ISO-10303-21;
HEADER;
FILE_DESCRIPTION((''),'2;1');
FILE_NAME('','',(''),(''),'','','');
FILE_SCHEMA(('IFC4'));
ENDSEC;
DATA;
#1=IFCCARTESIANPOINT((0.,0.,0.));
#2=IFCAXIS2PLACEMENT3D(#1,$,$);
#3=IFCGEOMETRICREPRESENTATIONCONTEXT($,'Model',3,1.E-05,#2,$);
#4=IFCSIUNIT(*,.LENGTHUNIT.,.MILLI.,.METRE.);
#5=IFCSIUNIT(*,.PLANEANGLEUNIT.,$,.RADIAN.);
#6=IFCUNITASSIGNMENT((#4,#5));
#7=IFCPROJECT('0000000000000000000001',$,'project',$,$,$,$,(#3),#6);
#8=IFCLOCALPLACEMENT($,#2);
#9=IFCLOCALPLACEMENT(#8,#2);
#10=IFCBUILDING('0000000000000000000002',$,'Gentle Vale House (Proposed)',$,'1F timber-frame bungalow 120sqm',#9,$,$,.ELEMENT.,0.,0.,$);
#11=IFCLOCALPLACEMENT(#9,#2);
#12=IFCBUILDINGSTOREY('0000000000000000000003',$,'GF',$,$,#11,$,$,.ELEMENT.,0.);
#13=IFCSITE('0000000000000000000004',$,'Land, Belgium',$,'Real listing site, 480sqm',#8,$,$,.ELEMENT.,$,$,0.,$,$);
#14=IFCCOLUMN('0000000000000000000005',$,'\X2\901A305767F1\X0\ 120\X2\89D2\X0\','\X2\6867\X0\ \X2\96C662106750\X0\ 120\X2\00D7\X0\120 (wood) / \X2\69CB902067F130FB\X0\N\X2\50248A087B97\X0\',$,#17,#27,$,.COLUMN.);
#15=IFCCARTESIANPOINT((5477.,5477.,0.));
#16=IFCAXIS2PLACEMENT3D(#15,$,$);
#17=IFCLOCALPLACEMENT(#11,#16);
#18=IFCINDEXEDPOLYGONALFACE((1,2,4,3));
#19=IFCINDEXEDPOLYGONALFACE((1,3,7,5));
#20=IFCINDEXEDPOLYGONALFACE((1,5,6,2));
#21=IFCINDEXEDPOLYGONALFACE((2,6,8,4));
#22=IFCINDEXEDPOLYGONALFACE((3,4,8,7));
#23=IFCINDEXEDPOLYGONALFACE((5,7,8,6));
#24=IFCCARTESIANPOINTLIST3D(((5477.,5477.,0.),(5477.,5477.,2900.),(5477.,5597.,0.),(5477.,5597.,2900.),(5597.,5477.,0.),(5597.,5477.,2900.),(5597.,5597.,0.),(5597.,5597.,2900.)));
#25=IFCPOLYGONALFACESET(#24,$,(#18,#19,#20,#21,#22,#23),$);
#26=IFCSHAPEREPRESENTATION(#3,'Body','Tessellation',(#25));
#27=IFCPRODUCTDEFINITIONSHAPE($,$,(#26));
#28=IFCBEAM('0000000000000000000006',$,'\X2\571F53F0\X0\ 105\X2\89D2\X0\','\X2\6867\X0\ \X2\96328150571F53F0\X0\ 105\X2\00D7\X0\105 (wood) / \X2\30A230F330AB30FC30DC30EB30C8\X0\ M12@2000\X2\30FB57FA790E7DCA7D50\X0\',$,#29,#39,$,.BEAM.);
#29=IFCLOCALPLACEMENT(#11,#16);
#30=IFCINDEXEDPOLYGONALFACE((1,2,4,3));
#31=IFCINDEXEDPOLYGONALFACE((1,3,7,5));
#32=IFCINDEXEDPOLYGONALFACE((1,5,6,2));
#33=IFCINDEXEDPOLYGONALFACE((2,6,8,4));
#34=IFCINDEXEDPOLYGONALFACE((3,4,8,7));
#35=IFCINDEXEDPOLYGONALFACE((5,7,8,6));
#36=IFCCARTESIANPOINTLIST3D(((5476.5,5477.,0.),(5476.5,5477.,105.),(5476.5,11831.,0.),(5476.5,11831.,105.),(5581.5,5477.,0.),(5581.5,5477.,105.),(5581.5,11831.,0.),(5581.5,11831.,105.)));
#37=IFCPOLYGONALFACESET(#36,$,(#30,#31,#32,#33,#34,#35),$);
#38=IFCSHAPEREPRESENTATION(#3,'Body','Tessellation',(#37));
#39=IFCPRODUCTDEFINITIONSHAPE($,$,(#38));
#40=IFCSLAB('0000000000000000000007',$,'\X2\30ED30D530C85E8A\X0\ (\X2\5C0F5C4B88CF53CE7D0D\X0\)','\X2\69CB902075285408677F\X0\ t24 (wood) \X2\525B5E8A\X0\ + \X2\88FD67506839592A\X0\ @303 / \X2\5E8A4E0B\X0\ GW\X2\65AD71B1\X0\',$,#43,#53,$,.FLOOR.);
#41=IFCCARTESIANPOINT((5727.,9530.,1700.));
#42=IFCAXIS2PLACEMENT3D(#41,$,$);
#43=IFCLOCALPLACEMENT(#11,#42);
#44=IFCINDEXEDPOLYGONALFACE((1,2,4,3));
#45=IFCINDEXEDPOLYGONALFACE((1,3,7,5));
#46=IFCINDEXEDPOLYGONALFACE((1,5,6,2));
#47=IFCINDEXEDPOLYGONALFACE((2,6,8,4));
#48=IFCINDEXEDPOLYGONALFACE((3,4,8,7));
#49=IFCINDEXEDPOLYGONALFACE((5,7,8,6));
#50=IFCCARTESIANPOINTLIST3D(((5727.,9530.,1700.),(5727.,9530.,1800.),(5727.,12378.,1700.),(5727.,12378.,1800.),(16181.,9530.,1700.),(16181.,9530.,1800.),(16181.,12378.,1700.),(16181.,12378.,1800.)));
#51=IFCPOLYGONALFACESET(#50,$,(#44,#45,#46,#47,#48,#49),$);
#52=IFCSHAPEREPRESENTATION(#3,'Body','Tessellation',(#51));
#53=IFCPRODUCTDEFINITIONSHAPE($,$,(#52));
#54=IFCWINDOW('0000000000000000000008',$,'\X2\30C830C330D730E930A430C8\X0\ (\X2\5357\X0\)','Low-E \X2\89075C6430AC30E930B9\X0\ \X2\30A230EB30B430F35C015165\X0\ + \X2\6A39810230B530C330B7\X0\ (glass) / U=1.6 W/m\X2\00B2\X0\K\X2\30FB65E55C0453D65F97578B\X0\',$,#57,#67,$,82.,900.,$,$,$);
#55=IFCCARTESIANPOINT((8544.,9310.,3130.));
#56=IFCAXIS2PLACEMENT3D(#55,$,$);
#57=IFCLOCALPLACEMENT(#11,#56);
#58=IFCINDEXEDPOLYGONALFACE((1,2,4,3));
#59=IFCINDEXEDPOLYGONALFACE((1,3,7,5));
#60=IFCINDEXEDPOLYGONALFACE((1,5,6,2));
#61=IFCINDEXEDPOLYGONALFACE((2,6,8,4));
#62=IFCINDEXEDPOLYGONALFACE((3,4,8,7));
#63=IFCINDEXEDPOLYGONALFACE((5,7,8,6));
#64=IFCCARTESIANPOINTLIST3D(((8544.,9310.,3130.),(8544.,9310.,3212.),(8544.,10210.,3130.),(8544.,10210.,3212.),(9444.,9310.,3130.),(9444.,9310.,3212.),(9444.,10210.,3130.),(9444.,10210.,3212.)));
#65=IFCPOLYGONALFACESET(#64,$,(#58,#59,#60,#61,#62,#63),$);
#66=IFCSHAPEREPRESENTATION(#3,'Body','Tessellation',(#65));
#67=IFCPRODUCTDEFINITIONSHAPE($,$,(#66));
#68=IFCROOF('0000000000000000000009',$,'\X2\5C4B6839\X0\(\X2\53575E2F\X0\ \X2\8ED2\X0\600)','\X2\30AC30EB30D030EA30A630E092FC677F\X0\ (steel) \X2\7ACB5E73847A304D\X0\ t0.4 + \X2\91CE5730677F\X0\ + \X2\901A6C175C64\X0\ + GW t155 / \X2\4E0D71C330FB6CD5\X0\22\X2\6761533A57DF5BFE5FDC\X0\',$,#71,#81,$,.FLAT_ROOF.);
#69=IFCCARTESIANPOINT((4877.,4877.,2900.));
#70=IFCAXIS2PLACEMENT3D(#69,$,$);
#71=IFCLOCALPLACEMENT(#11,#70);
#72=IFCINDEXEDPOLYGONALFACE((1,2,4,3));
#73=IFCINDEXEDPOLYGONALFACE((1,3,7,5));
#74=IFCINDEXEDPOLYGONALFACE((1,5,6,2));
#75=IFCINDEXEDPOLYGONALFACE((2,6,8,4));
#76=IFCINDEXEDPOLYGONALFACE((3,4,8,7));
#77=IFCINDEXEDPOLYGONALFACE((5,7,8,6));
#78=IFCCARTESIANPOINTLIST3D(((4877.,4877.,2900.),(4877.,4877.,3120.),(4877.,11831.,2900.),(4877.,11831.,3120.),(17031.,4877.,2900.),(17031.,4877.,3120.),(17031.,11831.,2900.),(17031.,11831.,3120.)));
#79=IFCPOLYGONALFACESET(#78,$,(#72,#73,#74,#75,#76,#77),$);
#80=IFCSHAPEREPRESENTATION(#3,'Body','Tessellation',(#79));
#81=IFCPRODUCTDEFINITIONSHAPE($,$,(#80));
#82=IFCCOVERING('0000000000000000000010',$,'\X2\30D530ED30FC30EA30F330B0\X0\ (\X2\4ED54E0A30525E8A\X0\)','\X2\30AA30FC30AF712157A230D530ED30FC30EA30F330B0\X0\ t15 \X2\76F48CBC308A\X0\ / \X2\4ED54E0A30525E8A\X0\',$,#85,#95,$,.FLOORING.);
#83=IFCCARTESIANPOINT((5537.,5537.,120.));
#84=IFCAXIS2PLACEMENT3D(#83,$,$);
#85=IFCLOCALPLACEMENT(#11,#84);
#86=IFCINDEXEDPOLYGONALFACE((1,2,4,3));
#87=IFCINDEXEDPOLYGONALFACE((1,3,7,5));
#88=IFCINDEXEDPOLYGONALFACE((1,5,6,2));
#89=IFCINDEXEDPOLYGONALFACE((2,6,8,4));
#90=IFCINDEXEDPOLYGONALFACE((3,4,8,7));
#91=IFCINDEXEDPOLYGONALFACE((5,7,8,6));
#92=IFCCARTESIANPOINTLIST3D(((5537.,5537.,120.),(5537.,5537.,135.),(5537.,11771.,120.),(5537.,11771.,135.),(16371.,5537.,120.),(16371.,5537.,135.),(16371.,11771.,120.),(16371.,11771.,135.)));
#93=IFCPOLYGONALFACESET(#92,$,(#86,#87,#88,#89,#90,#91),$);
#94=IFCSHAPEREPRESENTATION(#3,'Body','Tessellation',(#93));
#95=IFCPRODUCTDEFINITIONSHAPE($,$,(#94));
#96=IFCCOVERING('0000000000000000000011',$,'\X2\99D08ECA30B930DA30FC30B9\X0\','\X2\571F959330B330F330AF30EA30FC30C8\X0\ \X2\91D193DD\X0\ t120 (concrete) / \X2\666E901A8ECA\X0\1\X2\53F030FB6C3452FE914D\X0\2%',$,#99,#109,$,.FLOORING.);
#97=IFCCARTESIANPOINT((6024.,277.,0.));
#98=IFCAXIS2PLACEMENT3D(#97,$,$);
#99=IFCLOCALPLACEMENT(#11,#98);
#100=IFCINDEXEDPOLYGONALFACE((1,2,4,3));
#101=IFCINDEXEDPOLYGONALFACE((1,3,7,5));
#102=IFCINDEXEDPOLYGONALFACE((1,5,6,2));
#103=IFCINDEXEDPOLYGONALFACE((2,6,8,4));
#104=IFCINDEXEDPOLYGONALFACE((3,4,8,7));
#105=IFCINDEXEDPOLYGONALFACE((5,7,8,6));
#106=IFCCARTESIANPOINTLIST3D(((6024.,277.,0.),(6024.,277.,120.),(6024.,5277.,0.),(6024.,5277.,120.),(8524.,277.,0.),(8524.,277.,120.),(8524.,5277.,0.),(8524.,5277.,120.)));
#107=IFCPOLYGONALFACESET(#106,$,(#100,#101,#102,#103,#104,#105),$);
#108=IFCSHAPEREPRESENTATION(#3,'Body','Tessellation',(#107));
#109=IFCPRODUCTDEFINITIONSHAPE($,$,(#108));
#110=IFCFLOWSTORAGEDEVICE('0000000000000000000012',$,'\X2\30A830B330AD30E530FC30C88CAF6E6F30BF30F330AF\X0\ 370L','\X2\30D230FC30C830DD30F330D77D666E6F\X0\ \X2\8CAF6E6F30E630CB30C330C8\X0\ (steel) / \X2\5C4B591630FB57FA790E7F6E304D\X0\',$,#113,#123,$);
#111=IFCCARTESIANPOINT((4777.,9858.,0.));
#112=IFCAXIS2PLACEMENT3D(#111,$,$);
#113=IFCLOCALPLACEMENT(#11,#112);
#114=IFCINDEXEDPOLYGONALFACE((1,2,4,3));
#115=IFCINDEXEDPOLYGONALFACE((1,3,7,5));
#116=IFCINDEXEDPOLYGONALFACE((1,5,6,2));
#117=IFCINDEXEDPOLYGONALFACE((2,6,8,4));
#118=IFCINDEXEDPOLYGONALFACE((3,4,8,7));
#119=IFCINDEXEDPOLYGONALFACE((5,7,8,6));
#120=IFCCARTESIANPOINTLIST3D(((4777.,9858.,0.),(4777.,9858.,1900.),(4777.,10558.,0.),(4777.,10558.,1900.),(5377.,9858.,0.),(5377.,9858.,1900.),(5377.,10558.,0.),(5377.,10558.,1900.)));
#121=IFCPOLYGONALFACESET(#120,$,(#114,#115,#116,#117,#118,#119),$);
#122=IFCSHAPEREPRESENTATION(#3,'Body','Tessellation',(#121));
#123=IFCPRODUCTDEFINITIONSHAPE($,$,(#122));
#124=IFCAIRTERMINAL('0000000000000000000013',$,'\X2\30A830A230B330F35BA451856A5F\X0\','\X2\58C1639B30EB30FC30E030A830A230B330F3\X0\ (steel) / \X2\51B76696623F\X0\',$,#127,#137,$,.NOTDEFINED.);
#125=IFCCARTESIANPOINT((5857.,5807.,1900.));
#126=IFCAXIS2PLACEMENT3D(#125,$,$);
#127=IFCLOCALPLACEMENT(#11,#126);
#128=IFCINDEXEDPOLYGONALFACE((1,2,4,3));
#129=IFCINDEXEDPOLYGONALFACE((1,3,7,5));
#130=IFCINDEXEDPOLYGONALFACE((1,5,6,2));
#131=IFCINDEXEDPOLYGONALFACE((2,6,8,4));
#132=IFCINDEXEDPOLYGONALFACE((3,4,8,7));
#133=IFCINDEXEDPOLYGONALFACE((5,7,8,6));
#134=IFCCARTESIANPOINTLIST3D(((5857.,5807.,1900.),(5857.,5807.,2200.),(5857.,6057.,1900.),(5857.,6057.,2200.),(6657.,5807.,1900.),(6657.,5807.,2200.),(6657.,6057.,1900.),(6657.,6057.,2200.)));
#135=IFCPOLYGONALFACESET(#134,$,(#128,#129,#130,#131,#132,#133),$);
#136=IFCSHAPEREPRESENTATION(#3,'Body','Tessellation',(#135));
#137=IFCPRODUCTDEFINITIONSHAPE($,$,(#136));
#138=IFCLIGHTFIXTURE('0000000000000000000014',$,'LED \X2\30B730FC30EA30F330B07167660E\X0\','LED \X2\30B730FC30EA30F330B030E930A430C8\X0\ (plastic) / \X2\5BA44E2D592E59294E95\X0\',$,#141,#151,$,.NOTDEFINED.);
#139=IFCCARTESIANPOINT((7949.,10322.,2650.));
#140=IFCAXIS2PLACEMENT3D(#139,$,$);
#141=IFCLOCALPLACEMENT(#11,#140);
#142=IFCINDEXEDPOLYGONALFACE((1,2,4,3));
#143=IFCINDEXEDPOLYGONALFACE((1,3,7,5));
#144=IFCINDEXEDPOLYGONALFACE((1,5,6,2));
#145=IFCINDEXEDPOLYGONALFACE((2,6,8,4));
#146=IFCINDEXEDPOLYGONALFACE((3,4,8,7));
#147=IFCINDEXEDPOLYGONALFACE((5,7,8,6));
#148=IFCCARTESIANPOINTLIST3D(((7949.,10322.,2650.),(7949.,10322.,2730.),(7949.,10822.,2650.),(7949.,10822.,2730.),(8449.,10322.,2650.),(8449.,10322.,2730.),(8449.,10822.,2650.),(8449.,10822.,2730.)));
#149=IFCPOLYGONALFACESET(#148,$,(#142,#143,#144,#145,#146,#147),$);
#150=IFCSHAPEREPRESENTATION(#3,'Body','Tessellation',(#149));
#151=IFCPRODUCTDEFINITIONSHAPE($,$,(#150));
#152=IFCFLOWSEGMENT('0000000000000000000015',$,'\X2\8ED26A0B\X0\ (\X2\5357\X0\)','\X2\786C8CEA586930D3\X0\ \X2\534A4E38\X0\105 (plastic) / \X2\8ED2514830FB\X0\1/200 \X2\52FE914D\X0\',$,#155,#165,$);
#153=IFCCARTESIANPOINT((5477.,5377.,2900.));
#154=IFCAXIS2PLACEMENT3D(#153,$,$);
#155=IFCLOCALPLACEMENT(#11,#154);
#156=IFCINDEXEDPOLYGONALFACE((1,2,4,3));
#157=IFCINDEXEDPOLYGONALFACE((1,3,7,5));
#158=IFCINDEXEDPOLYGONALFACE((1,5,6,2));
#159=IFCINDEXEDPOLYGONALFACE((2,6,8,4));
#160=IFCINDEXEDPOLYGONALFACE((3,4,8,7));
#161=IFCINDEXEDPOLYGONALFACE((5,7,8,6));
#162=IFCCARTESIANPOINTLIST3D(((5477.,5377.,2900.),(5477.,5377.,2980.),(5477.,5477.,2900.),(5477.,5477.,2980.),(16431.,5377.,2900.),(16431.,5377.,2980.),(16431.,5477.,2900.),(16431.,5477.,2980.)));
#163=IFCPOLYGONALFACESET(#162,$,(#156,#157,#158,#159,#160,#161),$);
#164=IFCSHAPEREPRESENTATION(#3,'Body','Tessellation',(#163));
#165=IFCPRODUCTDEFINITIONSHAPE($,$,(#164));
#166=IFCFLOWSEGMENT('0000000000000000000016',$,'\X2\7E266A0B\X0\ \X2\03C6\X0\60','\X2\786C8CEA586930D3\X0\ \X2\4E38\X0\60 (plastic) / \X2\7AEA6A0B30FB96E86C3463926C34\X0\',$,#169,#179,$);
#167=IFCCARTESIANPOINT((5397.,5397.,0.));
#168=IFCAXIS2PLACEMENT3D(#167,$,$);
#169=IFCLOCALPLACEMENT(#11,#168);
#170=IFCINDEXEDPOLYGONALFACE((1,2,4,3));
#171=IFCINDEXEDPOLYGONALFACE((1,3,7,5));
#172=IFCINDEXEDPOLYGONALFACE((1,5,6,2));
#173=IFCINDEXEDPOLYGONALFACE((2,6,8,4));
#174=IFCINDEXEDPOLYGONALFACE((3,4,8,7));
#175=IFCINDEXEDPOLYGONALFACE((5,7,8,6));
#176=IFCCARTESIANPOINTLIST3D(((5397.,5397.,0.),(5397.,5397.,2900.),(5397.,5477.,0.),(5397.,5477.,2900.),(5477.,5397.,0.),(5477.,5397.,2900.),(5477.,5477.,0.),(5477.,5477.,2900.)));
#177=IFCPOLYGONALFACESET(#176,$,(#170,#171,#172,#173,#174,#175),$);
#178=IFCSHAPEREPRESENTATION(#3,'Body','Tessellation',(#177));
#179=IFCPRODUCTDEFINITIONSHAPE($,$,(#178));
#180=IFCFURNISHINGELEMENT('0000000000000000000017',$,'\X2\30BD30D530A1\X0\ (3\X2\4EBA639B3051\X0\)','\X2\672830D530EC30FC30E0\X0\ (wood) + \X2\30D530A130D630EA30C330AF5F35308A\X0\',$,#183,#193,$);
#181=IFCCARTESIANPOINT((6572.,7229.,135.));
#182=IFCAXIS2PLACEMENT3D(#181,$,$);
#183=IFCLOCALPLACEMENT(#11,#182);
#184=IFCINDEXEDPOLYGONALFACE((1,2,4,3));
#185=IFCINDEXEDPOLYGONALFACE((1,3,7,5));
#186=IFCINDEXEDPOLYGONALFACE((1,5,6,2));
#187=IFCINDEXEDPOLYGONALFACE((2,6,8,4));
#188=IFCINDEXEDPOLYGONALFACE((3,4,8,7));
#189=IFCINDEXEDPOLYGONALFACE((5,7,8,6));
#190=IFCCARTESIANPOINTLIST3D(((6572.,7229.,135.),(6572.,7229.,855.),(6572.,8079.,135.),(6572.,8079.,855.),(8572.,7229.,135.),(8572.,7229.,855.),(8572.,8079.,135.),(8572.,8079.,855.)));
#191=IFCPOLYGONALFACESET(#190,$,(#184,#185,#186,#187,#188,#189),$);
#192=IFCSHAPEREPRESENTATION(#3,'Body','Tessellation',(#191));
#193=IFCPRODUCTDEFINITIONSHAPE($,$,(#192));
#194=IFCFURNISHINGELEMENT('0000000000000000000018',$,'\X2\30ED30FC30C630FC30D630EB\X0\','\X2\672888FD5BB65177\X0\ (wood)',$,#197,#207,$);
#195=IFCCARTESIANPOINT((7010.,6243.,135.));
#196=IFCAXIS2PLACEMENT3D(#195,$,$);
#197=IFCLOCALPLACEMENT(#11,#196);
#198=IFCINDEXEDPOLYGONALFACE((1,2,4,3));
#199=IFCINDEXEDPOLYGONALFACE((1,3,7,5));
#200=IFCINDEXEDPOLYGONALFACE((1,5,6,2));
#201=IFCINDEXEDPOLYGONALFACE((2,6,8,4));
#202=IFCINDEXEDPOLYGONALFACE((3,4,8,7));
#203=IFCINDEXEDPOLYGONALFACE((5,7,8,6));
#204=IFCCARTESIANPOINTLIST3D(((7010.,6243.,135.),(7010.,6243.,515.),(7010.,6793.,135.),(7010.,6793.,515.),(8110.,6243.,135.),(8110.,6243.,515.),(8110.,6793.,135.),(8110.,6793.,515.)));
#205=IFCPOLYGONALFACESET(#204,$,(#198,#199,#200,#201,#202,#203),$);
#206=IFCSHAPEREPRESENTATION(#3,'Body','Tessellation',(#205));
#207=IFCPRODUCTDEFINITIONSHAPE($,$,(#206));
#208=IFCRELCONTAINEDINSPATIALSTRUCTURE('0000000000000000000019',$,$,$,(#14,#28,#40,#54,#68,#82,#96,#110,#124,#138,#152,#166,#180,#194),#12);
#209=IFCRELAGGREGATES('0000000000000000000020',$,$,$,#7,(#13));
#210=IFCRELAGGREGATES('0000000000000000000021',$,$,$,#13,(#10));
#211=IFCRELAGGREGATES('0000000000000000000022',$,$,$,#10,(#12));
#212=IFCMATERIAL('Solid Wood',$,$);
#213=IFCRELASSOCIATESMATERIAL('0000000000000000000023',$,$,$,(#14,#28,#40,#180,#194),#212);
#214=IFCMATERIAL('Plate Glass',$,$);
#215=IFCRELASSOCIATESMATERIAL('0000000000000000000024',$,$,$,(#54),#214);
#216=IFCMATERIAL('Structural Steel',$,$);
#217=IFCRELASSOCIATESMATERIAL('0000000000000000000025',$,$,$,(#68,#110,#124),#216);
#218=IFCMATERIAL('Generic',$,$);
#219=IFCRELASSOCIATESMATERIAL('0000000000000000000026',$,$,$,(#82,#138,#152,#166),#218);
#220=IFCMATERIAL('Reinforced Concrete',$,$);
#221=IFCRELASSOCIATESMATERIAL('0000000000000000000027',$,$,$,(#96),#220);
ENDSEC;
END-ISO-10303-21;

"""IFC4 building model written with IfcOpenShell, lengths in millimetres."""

from ifc_helpers import new_model, si_unit, frame, frame_2d, origin, place, context, project, spatial, rectangle, extrude, material, element, save


model = new_model("IFC4")

# Units and contexts
model_context = context("Model", 3, precision=1e-05, world=origin())
ifc_project = project(units=[si_unit("LENGTHUNIT", "METRE", prefix="MILLI"), si_unit("PLANEANGLEUNIT", "RADIAN")], contexts=[model_context])

# Site, building, storey
site_placement = place(None, origin())
site = spatial("IfcSite", under=ifc_project, at=site_placement, Name="Land, Belgium", ObjectType="Real listing site, 480sqm", CompositionType="ELEMENT", RefElevation=0.0)
building_placement = place(site_placement, origin())
building = spatial("IfcBuilding", under=site, at=building_placement, Name="Gentle Vale House (Proposed)", ObjectType="1F timber-frame bungalow 120sqm", CompositionType="ELEMENT", ElevationOfRefHeight=0.0, ElevationOfTerrain=0.0)
storey_placement = place(building_placement, origin())
storey = spatial("IfcBuildingStorey", under=building, at=storey_placement, Name="GF", CompositionType="ELEMENT", Elevation=0.0)

# Column
ifc_material_1 = material(Name="Solid Wood")
column_1_placement = place(storey_placement, frame((5477.0, 5477.0, 0.0)))
element("IfcColumn", 1, at=column_1_placement, inside=storey, material=ifc_material_1, Name="通し柱 120角", Description="桧 集成材 120×120 (wood) / 構造柱・N値計算", PredefinedType="COLUMN", context=model_context, shape_type="SweptSolid", body=[
    extrude(rectangle(XDim=120.0, YDim=120.0, at=frame_2d((60.0, 60.0))), frame((5477.0, 5477.0, 0.0)), (0.0, 0.0, 1.0), 2900.0),
])

# Beam
beam_1_placement = place(storey_placement, frame((5477.0, 5477.0, 0.0)))
element("IfcBeam", 2, at=beam_1_placement, inside=storey, material=ifc_material_1, Name="土台 105角", Description="桧 防腐土台 105×105 (wood) / アンカーボルト M12@2000・基礎緊結", PredefinedType="BEAM", context=model_context, shape_type="SweptSolid", body=[
    extrude(rectangle(XDim=105.0, YDim=6354.0, at=frame_2d((52.0, 3177.0))), frame((5477.0, 5477.0, 0.0)), (0.0, 0.0, 1.0), 105.0),
])

# Slab
ifc_material_2 = material(Name="Reinforced Concrete")
slab_1_placement = place(storey_placement, frame((5727.0, 9530.0, 1700.0)))
element("IfcSlab", 3, at=slab_1_placement, inside=storey, material=ifc_material_1, Name="ロフト床 (小屋裏収納)", Description="構造用合板 t24 (wood) 剛床 + 製材根太 @303 / 床下 GW断熱", PredefinedType="FLOOR", context=model_context, shape_type="SweptSolid", body=[
    extrude(rectangle(XDim=10454.0, YDim=2848.0, at=frame_2d((5227.0, 1424.0))), frame((5727.0, 9530.0, 1700.0)), (0.0, 0.0, 1.0), 100.0),
])

# Shared definitions
ifc_material_3 = material(Name="Plate Glass")

# Window
window_1_placement = place(storey_placement, frame((8544.0, 9310.0, 3130.0)))
element("IfcWindow", 4, at=window_1_placement, inside=storey, material=ifc_material_3, Name="トップライト (南)", Description="Low-E 複層ガラス アルゴン封入 + 樹脂サッシ (glass) / U=1.6 W/m²K・日射取得型", OverallHeight=82.0, OverallWidth=900.0, context=model_context, shape_type="SweptSolid", body=[
    extrude(rectangle(XDim=900.0, YDim=900.0, at=frame_2d((450.0, 450.0))), frame((8544.0, 9310.0, 3130.0)), (0.0, 0.0, 1.0), 82.0),
])

# Roof
ifc_material_4 = material(Name="Structural Steel")
roof_placement = place(storey_placement, frame((4877.0, 4877.0, 2900.0)))
element("IfcRoof", 5, at=roof_placement, inside=storey, material=ifc_material_4, Name="屋根(南帯 軒600)", Description="ガルバリウム鋼板 (steel) 立平葺き t0.4 + 野地板 + 通気層 + GW t155 / 不燃・法22条区域対応", PredefinedType="FLAT_ROOF", context=model_context, shape_type="SweptSolid", body=[
    extrude(rectangle(XDim=12154.0, YDim=6954.0, at=frame_2d((6077.0, 3477.0))), frame((4877.0, 4877.0, 2900.0)), (0.0, 0.0, 1.0), 220.0),
])

# Coverings
ifc_material_5 = material(Name="Generic")
covering_1_placement = place(storey_placement, frame((5537.0, 5537.0, 120.0)))
element("IfcCovering", 6, at=covering_1_placement, inside=storey, material=ifc_material_5, Name="フローリング (仕上げ床)", Description="オーク無垢フローリング t15 直貼り / 仕上げ床", PredefinedType="FLOORING", context=model_context, shape_type="SweptSolid", body=[
    extrude(rectangle(XDim=10834.0, YDim=6234.0, at=frame_2d((5417.0, 3117.0))), frame((5537.0, 5537.0, 120.0)), (0.0, 0.0, 1.0), 15.0),
])
covering_2_placement = place(storey_placement, frame((6024.0, 277.0, 0.0)))
element("IfcCovering", 7, at=covering_2_placement, inside=storey, material=ifc_material_2, Name="駐車スペース", Description="土間コンクリート 金鏝 t120 (concrete) / 普通車1台・水勾配2%", PredefinedType="FLOORING", context=model_context, shape_type="SweptSolid", body=[
    extrude(rectangle(XDim=2500.0, YDim=5000.0, at=frame_2d((1250.0, 2500.0))), frame((6024.0, 277.0, 0.0)), (0.0, 0.0, 1.0), 120.0),
])

# Flow storage device
flow_storage_device_placement = place(storey_placement, frame((4777.0, 9858.0, 0.0)))
element("IfcFlowStorageDevice", 8, at=flow_storage_device_placement, inside=storey, material=ifc_material_4, Name="エコキュート貯湯タンク 370L", Description="ヒートポンプ給湯 貯湯ユニット (steel) / 屋外・基礎置き", context=model_context, shape_type="SweptSolid", body=[
    extrude(rectangle(XDim=600.0, YDim=700.0, at=frame_2d((300.0, 350.0))), frame((4777.0, 9858.0, 0.0)), (0.0, 0.0, 1.0), 1900.0),
])

# Air terminal
air_terminal_placement = place(storey_placement, frame((5857.0, 5807.0, 1900.0)))
element("IfcAirTerminal", 9, at=air_terminal_placement, inside=storey, material=ifc_material_4, Name="エアコン室内機", Description="壁掛ルームエアコン (steel) / 冷暖房", PredefinedType="NOTDEFINED", context=model_context, shape_type="SweptSolid", body=[
    extrude(rectangle(XDim=800.0, YDim=250.0, at=frame_2d((400.0, 125.0))), frame((5857.0, 5807.0, 1900.0)), (0.0, 0.0, 1.0), 300.0),
])

# Light fixture
light_fixture_placement = place(storey_placement, frame((7949.0, 10322.0, 2650.0)))
element("IfcLightFixture", 10, at=light_fixture_placement, inside=storey, material=ifc_material_5, Name="LED シーリング照明", Description="LED シーリングライト (plastic) / 室中央天井", PredefinedType="NOTDEFINED", context=model_context, shape_type="SweptSolid", body=[
    extrude(rectangle(XDim=500.0, YDim=500.0, at=frame_2d((250.0, 250.0))), frame((7949.0, 10322.0, 2650.0)), (0.0, 0.0, 1.0), 80.0),
])

# Flow segments
flow_segment_1_placement = place(storey_placement, frame((5477.0, 5377.0, 2900.0)))
element("IfcFlowSegment", 11, at=flow_segment_1_placement, inside=storey, material=ifc_material_5, Name="軒樋 (南)", Description="硬質塩ビ 半丸105 (plastic) / 軒先・1/200 勾配", context=model_context, shape_type="SweptSolid", body=[
    extrude(rectangle(XDim=10954.0, YDim=100.0, at=frame_2d((5477.0, 50.0))), frame((5477.0, 5377.0, 2900.0)), (0.0, 0.0, 1.0), 80.0),
])
flow_segment_2_placement = place(storey_placement, frame((5397.0, 5397.0, 0.0)))
element("IfcFlowSegment", 12, at=flow_segment_2_placement, inside=storey, material=ifc_material_5, Name="縦樋 φ60", Description="硬質塩ビ 丸60 (plastic) / 竪樋・雨水排水", context=model_context, shape_type="SweptSolid", body=[
    extrude(rectangle(XDim=80.0, YDim=80.0, at=frame_2d((40.0, 40.0))), frame((5397.0, 5397.0, 0.0)), (0.0, 0.0, 1.0), 2900.0),
])

# Furnishing elements
furnishing_1_placement = place(storey_placement, frame((6572.0, 7229.0, 135.0)))
element("IfcFurnishingElement", 13, at=furnishing_1_placement, inside=storey, material=ifc_material_1, Name="ソファ (3人掛け)", Description="木フレーム (wood) + ファブリック張り", context=model_context, shape_type="SweptSolid", body=[
    extrude(rectangle(XDim=2000.0, YDim=850.0, at=frame_2d((1000.0, 425.0))), frame((6572.0, 7229.0, 135.0)), (0.0, 0.0, 1.0), 720.0),
])
furnishing_2_placement = place(storey_placement, frame((7010.0, 6243.0, 135.0)))
element("IfcFurnishingElement", 14, at=furnishing_2_placement, inside=storey, material=ifc_material_1, Name="ローテーブル", Description="木製家具 (wood)", context=model_context, shape_type="SweptSolid", body=[
    extrude(rectangle(XDim=1100.0, YDim=550.0, at=frame_2d((550.0, 275.0))), frame((7010.0, 6243.0, 135.0)), (0.0, 0.0, 1.0), 380.0),
])

save(model, "model.ifc")
